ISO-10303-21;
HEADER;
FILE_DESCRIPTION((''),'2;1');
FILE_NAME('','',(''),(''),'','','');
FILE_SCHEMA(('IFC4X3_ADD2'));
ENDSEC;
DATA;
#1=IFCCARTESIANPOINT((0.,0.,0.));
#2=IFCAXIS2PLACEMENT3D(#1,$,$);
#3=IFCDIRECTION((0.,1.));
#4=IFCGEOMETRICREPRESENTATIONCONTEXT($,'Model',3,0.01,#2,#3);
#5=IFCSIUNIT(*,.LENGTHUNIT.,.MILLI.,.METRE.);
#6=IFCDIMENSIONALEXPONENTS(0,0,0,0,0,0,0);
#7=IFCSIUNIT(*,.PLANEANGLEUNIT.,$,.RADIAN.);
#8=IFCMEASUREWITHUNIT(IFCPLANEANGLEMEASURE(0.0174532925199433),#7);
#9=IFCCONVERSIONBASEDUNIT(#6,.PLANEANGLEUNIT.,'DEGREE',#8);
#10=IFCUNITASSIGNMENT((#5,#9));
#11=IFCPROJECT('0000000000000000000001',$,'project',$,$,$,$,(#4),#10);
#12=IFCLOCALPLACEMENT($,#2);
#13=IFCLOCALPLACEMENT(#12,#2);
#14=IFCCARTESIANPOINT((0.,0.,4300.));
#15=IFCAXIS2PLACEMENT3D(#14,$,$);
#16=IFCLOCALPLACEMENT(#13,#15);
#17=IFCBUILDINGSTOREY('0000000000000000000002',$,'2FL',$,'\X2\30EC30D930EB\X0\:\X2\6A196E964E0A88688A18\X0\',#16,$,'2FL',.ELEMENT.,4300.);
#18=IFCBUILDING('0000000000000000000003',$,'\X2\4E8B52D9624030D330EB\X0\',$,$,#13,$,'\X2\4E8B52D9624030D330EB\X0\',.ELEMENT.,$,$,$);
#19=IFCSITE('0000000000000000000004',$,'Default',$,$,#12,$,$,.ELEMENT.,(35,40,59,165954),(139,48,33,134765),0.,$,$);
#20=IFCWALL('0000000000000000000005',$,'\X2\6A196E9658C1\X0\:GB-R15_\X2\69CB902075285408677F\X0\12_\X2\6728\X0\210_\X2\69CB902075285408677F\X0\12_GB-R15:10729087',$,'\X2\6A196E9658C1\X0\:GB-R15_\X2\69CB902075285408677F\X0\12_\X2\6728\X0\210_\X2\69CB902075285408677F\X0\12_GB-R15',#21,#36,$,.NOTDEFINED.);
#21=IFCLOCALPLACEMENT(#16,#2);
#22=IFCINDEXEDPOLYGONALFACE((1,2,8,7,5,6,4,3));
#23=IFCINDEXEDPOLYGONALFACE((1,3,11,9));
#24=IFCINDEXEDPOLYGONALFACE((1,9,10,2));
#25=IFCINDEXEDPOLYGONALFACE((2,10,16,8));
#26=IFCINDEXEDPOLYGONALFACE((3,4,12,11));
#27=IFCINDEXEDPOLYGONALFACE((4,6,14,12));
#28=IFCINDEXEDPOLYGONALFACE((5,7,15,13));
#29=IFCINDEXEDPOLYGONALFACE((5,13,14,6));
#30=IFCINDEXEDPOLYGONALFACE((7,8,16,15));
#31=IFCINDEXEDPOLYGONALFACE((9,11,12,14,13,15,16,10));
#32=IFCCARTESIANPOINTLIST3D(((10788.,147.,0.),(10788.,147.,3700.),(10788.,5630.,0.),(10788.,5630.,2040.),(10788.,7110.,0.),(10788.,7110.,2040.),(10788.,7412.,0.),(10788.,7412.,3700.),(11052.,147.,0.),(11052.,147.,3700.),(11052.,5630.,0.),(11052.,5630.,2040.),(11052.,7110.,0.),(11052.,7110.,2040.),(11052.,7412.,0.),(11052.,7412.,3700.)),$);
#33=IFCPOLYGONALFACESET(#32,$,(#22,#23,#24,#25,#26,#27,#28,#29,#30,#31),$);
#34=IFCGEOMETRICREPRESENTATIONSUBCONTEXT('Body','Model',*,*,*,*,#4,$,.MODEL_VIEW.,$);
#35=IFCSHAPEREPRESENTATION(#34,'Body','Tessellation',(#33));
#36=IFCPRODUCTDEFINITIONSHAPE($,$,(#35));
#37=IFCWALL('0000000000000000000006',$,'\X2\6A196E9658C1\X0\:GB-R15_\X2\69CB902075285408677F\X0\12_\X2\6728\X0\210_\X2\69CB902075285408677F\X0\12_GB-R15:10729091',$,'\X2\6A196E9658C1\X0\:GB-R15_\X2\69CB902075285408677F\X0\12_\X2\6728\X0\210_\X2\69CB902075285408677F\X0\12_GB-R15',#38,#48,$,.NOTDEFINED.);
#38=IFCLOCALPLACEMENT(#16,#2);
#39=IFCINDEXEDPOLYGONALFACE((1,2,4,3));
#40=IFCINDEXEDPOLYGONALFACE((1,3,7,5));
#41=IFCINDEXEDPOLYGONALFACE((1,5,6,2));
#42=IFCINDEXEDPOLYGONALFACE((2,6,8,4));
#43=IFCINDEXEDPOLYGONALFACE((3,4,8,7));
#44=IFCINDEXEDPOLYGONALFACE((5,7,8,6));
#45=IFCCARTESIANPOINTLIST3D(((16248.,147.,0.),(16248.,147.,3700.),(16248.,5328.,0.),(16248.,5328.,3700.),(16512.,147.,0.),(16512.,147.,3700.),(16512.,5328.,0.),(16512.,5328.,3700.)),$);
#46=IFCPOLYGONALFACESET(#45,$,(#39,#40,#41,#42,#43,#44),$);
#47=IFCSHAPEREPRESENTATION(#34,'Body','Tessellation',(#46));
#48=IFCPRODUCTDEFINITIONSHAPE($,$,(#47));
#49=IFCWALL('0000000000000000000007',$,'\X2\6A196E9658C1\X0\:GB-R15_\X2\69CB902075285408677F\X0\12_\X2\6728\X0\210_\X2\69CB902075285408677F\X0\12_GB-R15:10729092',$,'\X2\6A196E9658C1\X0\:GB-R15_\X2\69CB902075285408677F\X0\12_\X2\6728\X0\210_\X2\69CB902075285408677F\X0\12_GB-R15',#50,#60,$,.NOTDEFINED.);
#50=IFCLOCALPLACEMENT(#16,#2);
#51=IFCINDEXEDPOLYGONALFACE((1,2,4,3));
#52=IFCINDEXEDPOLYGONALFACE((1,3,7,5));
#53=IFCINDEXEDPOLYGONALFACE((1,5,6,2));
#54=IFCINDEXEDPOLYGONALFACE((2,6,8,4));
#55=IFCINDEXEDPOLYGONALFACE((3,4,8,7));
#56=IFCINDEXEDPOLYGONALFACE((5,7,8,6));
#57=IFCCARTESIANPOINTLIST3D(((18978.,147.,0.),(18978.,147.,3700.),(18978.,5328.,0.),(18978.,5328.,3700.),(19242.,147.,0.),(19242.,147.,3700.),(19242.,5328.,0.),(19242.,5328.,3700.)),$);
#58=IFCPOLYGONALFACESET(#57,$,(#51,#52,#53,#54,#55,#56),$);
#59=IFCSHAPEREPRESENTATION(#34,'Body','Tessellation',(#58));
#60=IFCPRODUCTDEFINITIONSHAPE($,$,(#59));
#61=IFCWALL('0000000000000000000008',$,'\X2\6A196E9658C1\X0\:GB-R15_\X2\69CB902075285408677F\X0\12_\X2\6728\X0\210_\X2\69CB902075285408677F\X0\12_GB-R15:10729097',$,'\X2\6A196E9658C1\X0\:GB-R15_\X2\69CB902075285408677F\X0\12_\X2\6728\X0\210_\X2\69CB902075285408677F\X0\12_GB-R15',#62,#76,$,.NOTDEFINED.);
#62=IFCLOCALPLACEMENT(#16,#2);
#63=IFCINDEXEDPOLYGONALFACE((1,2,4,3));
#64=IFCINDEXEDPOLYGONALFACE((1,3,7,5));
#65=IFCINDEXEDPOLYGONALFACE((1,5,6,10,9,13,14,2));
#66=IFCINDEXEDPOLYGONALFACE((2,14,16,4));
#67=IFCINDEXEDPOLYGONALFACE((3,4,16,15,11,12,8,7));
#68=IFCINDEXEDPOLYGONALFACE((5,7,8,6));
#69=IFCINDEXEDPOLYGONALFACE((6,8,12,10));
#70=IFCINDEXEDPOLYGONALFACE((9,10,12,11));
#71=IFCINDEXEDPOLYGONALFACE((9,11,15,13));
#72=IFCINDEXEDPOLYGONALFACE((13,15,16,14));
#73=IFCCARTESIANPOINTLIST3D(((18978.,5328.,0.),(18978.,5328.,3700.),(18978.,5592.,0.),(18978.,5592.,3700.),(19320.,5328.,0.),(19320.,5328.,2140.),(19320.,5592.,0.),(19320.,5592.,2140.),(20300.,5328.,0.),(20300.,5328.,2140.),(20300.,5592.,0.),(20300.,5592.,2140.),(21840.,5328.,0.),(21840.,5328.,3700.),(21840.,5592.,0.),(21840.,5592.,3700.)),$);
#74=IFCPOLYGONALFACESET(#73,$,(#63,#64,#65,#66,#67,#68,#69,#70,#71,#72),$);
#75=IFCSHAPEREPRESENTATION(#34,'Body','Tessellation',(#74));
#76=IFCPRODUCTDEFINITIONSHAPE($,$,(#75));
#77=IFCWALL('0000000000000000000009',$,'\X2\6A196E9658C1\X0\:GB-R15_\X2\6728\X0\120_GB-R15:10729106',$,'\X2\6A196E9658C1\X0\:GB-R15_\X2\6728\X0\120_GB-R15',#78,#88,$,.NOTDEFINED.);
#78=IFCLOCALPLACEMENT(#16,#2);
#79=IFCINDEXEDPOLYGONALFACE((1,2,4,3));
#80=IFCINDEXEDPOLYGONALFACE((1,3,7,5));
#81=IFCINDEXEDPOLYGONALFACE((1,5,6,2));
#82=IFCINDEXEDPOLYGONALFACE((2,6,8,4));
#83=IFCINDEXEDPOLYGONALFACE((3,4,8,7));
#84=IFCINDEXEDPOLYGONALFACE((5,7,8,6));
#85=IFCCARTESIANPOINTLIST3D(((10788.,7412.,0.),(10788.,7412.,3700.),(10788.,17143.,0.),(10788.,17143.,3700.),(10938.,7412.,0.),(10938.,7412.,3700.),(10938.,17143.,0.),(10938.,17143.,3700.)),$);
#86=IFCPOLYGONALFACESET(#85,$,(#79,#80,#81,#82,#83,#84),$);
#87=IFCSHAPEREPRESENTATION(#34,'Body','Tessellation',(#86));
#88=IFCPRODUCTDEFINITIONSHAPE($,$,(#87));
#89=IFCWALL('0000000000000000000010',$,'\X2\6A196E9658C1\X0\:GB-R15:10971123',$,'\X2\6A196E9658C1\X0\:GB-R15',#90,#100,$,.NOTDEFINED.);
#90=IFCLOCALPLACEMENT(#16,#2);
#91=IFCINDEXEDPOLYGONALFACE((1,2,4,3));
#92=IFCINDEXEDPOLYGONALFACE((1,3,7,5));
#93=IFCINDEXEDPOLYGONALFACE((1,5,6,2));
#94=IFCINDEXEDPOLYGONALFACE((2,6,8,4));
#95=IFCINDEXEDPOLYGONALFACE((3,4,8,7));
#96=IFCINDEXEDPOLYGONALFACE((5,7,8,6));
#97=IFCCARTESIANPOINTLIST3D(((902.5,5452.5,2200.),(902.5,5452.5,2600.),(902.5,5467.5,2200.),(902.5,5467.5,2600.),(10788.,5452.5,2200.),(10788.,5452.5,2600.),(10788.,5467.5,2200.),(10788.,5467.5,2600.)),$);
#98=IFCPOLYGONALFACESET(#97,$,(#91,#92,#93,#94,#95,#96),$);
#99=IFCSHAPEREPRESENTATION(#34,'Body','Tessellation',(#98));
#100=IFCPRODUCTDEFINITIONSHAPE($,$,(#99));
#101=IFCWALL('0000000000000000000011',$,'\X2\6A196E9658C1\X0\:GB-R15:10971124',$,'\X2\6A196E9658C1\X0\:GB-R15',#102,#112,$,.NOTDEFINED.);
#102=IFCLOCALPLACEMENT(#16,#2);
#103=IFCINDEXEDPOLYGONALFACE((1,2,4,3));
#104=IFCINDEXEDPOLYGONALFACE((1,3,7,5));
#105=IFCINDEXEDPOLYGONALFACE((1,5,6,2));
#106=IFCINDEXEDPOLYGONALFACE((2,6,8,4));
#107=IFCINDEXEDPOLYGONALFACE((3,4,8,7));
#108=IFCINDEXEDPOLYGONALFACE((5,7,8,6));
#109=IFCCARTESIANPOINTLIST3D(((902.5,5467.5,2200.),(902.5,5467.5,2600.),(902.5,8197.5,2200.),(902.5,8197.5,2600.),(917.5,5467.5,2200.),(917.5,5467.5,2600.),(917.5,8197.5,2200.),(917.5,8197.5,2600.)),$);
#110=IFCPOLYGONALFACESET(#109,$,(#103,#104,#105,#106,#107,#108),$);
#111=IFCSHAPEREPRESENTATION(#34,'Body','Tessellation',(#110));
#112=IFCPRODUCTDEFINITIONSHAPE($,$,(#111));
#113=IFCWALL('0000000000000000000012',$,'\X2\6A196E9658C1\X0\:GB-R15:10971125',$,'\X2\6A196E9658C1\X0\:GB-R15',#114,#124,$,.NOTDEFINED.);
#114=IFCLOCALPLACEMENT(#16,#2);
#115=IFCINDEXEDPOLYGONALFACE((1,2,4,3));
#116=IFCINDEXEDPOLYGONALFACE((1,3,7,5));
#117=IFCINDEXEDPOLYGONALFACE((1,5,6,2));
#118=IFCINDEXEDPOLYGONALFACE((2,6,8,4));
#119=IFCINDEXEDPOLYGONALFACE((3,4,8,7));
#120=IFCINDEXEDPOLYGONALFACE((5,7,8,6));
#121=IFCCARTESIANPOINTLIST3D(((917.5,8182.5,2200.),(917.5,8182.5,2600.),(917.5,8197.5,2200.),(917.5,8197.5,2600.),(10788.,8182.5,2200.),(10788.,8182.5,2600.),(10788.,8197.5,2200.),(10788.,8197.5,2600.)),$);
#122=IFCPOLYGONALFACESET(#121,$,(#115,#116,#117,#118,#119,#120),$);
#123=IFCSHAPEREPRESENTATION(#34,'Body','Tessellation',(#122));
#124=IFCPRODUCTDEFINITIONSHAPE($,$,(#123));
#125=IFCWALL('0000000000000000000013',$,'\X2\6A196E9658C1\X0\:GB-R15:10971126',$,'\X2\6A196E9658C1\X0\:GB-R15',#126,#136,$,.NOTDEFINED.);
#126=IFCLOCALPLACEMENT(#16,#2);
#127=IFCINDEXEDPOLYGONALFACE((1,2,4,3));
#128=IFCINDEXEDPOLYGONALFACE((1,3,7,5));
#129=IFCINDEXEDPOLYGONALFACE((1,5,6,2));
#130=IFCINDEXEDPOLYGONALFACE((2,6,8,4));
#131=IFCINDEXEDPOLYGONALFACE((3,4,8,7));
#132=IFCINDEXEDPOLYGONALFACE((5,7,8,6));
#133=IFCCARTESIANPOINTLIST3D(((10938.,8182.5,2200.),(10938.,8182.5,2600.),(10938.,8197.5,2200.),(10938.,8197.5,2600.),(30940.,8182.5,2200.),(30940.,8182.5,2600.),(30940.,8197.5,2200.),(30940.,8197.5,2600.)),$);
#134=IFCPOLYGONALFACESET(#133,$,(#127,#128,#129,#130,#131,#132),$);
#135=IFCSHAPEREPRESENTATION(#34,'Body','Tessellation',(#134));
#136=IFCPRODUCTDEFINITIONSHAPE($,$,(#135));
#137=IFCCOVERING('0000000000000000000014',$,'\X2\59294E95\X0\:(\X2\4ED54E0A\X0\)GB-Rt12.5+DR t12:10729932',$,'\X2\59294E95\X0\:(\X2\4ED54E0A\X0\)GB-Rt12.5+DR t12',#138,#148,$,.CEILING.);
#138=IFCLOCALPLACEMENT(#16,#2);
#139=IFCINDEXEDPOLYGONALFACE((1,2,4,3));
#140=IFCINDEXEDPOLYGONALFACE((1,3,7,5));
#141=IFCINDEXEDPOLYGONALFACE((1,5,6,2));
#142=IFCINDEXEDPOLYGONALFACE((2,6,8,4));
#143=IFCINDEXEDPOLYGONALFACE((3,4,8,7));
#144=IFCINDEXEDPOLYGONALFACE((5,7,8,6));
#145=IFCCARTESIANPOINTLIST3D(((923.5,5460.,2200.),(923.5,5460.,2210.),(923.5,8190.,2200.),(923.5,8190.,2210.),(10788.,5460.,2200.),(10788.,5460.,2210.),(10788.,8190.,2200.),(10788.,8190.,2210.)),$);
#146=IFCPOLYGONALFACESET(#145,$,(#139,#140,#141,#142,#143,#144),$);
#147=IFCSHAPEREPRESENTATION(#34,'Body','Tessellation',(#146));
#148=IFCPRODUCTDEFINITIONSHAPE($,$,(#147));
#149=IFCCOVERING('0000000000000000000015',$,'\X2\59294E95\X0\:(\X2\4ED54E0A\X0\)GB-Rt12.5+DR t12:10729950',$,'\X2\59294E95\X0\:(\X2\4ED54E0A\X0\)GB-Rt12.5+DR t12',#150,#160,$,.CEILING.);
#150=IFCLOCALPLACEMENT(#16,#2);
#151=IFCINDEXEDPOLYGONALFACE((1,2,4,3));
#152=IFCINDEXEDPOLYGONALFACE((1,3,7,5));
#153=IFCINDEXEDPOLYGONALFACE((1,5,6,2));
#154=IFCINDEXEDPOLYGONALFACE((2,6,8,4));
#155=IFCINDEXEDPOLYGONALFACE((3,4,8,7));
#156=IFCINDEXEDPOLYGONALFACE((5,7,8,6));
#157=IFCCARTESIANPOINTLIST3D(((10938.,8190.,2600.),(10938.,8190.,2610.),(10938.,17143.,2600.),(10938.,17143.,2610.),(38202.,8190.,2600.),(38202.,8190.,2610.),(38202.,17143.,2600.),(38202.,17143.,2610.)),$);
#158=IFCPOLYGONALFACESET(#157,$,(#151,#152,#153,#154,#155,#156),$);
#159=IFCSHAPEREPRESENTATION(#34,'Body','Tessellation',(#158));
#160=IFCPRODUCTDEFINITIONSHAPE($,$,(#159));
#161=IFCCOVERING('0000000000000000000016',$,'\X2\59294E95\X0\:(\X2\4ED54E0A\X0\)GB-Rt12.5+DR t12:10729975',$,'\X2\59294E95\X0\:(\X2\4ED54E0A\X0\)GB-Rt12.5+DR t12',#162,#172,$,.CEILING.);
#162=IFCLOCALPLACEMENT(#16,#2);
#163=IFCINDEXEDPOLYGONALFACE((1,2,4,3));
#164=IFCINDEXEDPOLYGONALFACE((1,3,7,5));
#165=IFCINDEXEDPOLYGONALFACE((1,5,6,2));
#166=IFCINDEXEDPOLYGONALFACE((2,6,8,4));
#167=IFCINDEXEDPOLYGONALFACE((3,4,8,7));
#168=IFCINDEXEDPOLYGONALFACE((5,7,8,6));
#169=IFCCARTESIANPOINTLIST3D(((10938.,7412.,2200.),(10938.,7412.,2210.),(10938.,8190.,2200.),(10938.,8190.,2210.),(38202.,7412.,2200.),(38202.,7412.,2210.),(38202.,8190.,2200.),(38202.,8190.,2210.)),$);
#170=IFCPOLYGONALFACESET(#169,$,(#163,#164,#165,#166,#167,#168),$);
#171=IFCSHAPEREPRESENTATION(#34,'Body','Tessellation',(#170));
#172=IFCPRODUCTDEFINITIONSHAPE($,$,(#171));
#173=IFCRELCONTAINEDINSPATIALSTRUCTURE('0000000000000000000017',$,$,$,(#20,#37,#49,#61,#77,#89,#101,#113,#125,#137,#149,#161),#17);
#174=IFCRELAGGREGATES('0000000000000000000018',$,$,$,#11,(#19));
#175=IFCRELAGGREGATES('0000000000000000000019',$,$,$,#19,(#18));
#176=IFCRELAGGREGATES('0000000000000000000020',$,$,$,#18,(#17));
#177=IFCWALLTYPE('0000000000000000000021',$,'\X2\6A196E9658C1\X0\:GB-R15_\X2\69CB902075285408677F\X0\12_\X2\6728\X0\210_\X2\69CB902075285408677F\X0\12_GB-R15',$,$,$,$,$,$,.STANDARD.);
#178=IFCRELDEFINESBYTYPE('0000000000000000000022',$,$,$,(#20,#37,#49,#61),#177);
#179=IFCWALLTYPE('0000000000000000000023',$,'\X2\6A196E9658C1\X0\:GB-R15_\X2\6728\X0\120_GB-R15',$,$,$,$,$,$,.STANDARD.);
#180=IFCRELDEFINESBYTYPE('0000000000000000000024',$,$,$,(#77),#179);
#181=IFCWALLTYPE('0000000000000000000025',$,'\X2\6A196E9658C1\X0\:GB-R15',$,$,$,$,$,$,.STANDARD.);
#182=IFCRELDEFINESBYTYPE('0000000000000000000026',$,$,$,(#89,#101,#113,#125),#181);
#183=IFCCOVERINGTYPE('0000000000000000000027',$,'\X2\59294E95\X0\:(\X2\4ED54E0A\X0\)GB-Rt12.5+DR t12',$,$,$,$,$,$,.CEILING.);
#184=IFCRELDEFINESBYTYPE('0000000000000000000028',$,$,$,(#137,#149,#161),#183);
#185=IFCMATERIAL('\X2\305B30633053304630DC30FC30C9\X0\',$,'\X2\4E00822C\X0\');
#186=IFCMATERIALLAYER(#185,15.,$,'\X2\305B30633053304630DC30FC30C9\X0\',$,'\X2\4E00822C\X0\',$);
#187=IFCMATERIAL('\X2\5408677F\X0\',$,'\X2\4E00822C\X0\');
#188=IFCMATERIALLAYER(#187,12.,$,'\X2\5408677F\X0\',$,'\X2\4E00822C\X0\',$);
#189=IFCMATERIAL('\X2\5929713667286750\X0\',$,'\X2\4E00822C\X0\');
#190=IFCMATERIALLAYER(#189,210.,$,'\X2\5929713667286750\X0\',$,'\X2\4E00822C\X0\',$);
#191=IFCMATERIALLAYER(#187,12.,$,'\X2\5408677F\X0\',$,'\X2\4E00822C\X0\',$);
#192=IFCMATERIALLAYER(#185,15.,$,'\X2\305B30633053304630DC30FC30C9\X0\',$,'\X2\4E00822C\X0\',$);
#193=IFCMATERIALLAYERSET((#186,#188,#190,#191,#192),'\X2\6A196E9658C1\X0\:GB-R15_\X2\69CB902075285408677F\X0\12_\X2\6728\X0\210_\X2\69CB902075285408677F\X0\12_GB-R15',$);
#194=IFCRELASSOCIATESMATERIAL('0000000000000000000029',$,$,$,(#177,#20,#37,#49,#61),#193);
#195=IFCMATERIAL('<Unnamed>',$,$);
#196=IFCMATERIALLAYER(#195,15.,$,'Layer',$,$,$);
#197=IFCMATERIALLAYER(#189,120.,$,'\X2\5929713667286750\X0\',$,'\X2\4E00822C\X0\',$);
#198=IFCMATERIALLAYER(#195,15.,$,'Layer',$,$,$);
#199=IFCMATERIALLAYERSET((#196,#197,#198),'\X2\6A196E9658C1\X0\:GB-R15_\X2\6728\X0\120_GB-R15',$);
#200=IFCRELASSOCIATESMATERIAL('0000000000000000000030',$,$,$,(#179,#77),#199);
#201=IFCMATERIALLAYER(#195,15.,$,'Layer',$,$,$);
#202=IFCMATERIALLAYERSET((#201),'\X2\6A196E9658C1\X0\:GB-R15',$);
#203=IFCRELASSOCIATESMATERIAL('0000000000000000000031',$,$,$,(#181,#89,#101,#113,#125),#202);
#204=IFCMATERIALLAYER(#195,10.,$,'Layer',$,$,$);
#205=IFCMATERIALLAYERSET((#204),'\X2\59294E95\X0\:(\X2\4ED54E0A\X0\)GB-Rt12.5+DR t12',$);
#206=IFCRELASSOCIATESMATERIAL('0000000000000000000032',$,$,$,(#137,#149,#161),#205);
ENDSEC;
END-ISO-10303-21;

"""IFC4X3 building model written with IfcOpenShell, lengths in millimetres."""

from ifc_helpers import new_model, entity, si_unit, converted_unit, direction, frame, frame_2d, origin, place, context, subcontext, project, spatial, rectangle, extrude, material, layer, layer_set, layer_usage, type_object, element, save


model = new_model("IFC4X3")

# Units and contexts
model_context = context("Model", 3, precision=0.01, world=origin(), true_north=direction((0.0, 1.0)))
body_context = subcontext(model_context, "Body", "Model", "MODEL_VIEW")
ifc_project = project(units=[si_unit("LENGTHUNIT", "METRE", prefix="MILLI"), converted_unit("PLANEANGLEUNIT", "DEGREE", entity("IfcPlaneAngleMeasure", 0.0174532925199433), si_unit("PLANEANGLEUNIT", "RADIAN"), dimensions=[0, 0, 0, 0, 0, 0, 0])], contexts=[model_context])

# Site, building, storey
site_placement = place(None, origin())
site = spatial("IfcSite", under=ifc_project, at=site_placement, Name="Default", CompositionType="ELEMENT", RefLatitude=(35, 40, 59, 165954), RefLongitude=(139, 48, 33, 134765), RefElevation=0.0)
building_placement = place(site_placement, origin())
building = spatial("IfcBuilding", under=site, at=building_placement, Name="事務所ビル", LongName="事務所ビル", CompositionType="ELEMENT")
storey_placement = place(building_placement, frame((0.0, 0.0, 4300.0)))
storey = spatial("IfcBuildingStorey", under=building, at=storey_placement, Name="2FL", ObjectType="レベル:標準上表記", LongName="2FL", CompositionType="ELEMENT", Elevation=4300.0)

# Shared definitions
ifc_material_1 = material(Name="<Unnamed>")
ifc_material_2 = material(Name="合板", Category="一般")

# Wall, opening
ifc_material_3 = material(Name="せっこうボード", Category="一般")
ifc_layer_1 = layer(ifc_material_3, 15.0, Name="せっこうボード", Category="一般")
ifc_layer_2 = layer(ifc_material_2, 12.0, Name="合板", Category="一般")
ifc_material_4 = material(Name="天然木材", Category="一般")
ifc_layer_3 = layer(ifc_material_4, 210.0, Name="天然木材", Category="一般")
ifc_layer_4 = layer(ifc_material_2, 12.0, Name="合板", Category="一般")
ifc_layer_5 = layer(ifc_material_3, 15.0, Name="せっこうボード", Category="一般")
ifc_layer_set_1 = layer_set([ifc_layer_1, ifc_layer_2, ifc_layer_3, ifc_layer_4, ifc_layer_5], Name="標準壁:GB-R15_構造用合板12_木210_構造用合板12_GB-R15")
wall_type_1 = type_object("IfcWallType", Name="標準壁:GB-R15_構造用合板12_木210_構造用合板12_GB-R15", PredefinedType="STANDARD", material=ifc_layer_set_1)
wall_1_placement = place(storey_placement, frame((10920.0, 147.0, 0.0), z_axis=(0.0, 0.0, 1.0), x_axis=(0.0, 1.0, 0.0)))
wall_1 = element("IfcWall", 1, at=wall_1_placement, inside=storey, type_object=wall_type_1, material=ifc_layer_set_1, Name="標準壁:GB-R15_構造用合板12_木210_構造用合板12_GB-R15:10729087", ObjectType="標準壁:GB-R15_構造用合板12_木210_構造用合板12_GB-R15", PredefinedType="NOTDEFINED", context=body_context, shape_type="SweptSolid", body=[
    extrude(rectangle(XDim=7265.0, YDim=264.0, at=frame_2d((3632.5, 0.0), x_axis=(1.0, 0.0))), origin(), (0.0, 0.0, 1.0), 3700.0),
])
opening_1_placement = place(wall_1_placement, frame((5483.0, -132.0, -15.0)))
element("IfcOpeningElement", 2, at=opening_1_placement, cuts=wall_1, PredefinedType="OPENING", context=body_context, shape_type="SweptSolid", body=[
    extrude(rectangle(XDim=2055.0, YDim=1480.0, at=frame_2d((1027.5, 740.0), x_axis=(-1.0, 0.0))), frame((0.0, 0.0, 0.0), z_axis=(0.0, 1.0, 0.0), x_axis=(0.0, 0.0, 1.0)), (0.0, 0.0, 1.0), 264.0),
])

# Walls
wall_2_placement = place(storey_placement, frame((16380.0, 147.0, 0.0), z_axis=(0.0, 0.0, 1.0), x_axis=(0.0, 1.0, 0.0)))
element("IfcWall", 3, at=wall_2_placement, inside=storey, type_object=wall_type_1, material=ifc_layer_set_1, Name="標準壁:GB-R15_構造用合板12_木210_構造用合板12_GB-R15:10729091", ObjectType="標準壁:GB-R15_構造用合板12_木210_構造用合板12_GB-R15", PredefinedType="NOTDEFINED", context=body_context, shape_type="SweptSolid", body=[
    extrude(rectangle(XDim=5181.0, YDim=264.0, at=frame_2d((2590.5, 0.0), x_axis=(-1.0, 0.0))), origin(), (0.0, 0.0, 1.0), 3700.0),
])
wall_3_placement = place(storey_placement, frame((19110.0, 147.0, 0.0), z_axis=(0.0, 0.0, 1.0), x_axis=(0.0, 1.0, 0.0)))
element("IfcWall", 4, at=wall_3_placement, inside=storey, type_object=wall_type_1, material=ifc_layer_set_1, Name="標準壁:GB-R15_構造用合板12_木210_構造用合板12_GB-R15:10729092", ObjectType="標準壁:GB-R15_構造用合板12_木210_構造用合板12_GB-R15", PredefinedType="NOTDEFINED", context=body_context, shape_type="SweptSolid", body=[
    extrude(rectangle(XDim=5181.0, YDim=264.0, at=frame_2d((2590.5, 0.0), x_axis=(-1.0, 0.0))), origin(), (0.0, 0.0, 1.0), 3700.0),
])

# Wall, openings
wall_4_placement = place(storey_placement, frame((18978.0, 5460.0, 0.0)))
wall_4 = element("IfcWall", 5, at=wall_4_placement, inside=storey, type_object=wall_type_1, material=ifc_layer_set_1, Name="標準壁:GB-R15_構造用合板12_木210_構造用合板12_GB-R15:10729097", ObjectType="標準壁:GB-R15_構造用合板12_木210_構造用合板12_GB-R15", PredefinedType="NOTDEFINED", context=body_context, shape_type="SweptSolid", body=[
    extrude(rectangle(XDim=2862.0, YDim=264.0, at=frame_2d((1431.0, 0.0), x_axis=(-1.0, 0.0))), origin(), (0.0, 0.0, 1.0), 3700.0),
])
opening_2_placement = place(wall_4_placement, frame((-18978.0, -5460.0, 3700.0)))
element("IfcOpeningElement", 6, at=opening_2_placement, cuts=wall_4, PredefinedType="OPENING", context=body_context, shape_type="SweptSolid", body=[
    extrude(rectangle(XDim=2140.0, YDim=980.0, at=frame_2d((0.0, 0.0), x_axis=(0.0, 1.0))), frame((19810.0, 3804.0, 1070.0), z_axis=(0.0, 1.0, 0.0), x_axis=(1.0, 0.0, 0.0)), (0.0, 0.0, 1.0), 3048.0),
])
opening_3_placement = place(wall_4_placement, frame((342.0, -132.0, 0.0)))
element("IfcOpeningElement", 7, at=opening_3_placement, cuts=wall_4, PredefinedType="OPENING", context=body_context, shape_type="SweptSolid", body=[
    extrude(rectangle(XDim=2140.0, YDim=980.0, at=frame_2d((1070.0, 490.0), x_axis=(-1.0, 0.0))), frame((0.0, 0.0, 0.0), z_axis=(0.0, 1.0, 0.0), x_axis=(0.0, 0.0, 1.0)), (0.0, 0.0, 1.0), 264.0),
])

# Walls
ifc_layer_6 = layer(ifc_material_1, 15.0, Name="Layer")
ifc_layer_7 = layer(ifc_material_4, 120.0, Name="天然木材", Category="一般")
ifc_layer_8 = layer(ifc_material_1, 15.0, Name="Layer")
ifc_layer_set_2 = layer_set([ifc_layer_6, ifc_layer_7, ifc_layer_8], Name="標準壁:GB-R15_木120_GB-R15")
wall_type_2 = type_object("IfcWallType", Name="標準壁:GB-R15_木120_GB-R15", PredefinedType="STANDARD", material=ifc_layer_set_2)
wall_5_placement = place(storey_placement, frame((10863.0, 7412.0, 0.0), z_axis=(0.0, 0.0, 1.0), x_axis=(0.0, 1.0, 0.0)))
element("IfcWall", 8, at=wall_5_placement, inside=storey, type_object=wall_type_2, material=ifc_layer_set_2, Name="標準壁:GB-R15_木120_GB-R15:10729106", ObjectType="標準壁:GB-R15_木120_GB-R15", PredefinedType="NOTDEFINED", context=body_context, shape_type="SweptSolid", body=[
    extrude(rectangle(XDim=9731.0, YDim=150.0, at=frame_2d((4865.5, 0.0), x_axis=(-1.0, 0.0))), origin(), (0.0, 0.0, 1.0), 3700.0),
])
ifc_layer_9 = layer(ifc_material_1, 15.0, Name="Layer")
ifc_layer_set_3 = layer_set([ifc_layer_9], Name="標準壁:GB-R15")
wall_type_3 = type_object("IfcWallType", Name="標準壁:GB-R15", PredefinedType="STANDARD", material=ifc_layer_set_3)
wall_6_placement = place(storey_placement, frame((10788.0, 5460.0, 2200.0), z_axis=(0.0, 0.0, 1.0), x_axis=(-1.0, 0.0, 0.0)))
element("IfcWall", 9, at=wall_6_placement, inside=storey, type_object=wall_type_3, material=ifc_layer_set_3, Name="標準壁:GB-R15:10971123", ObjectType="標準壁:GB-R15", PredefinedType="NOTDEFINED", context=body_context, shape_type="SweptSolid", body=[
    extrude(rectangle(XDim=9885.5, YDim=15.0, at=frame_2d((4942.8, 0.0), x_axis=(-1.0, 0.0))), origin(), (0.0, 0.0, 1.0), 400.0),
])
wall_7_placement = place(storey_placement, frame((910.0, 5467.5, 2200.0), z_axis=(0.0, 0.0, 1.0), x_axis=(0.0, 1.0, 0.0)))
element("IfcWall", 10, at=wall_7_placement, inside=storey, type_object=wall_type_3, material=ifc_layer_set_3, Name="標準壁:GB-R15:10971124", ObjectType="標準壁:GB-R15", PredefinedType="NOTDEFINED", context=body_context, shape_type="SweptSolid", body=[
    extrude(rectangle(XDim=2730.0, YDim=15.0, at=frame_2d((1365.0, 0.0), x_axis=(-1.0, 0.0))), origin(), (0.0, 0.0, 1.0), 400.0),
])
wall_8_placement = place(storey_placement, frame((917.5, 8190.0, 2200.0)))
element("IfcWall", 11, at=wall_8_placement, inside=storey, type_object=wall_type_3, material=ifc_layer_set_3, Name="標準壁:GB-R15:10971125", ObjectType="標準壁:GB-R15", PredefinedType="NOTDEFINED", context=body_context, shape_type="SweptSolid", body=[
    extrude(rectangle(XDim=9870.5, YDim=15.0, at=frame_2d((4935.2, 0.0), x_axis=(-1.0, 0.0))), origin(), (0.0, 0.0, 1.0), 400.0),
])
wall_9_placement = place(storey_placement, frame((10938.0, 8190.0, 2200.0)))
element("IfcWall", 12, at=wall_9_placement, inside=storey, type_object=wall_type_3, material=ifc_layer_set_3, Name="標準壁:GB-R15:10971126", ObjectType="標準壁:GB-R15", PredefinedType="NOTDEFINED", context=body_context, shape_type="SweptSolid", body=[
    extrude(rectangle(XDim=20002.0, YDim=15.0, at=frame_2d((10001.0, 0.0), x_axis=(-1.0, 0.0))), origin(), (0.0, 0.0, 1.0), 400.0),
])

# Covering
ifc_layer_10 = layer(ifc_material_1, 10.0, Name="Layer")
ifc_layer_set_4 = layer_set([ifc_layer_10], Name="天井:(仕上)GB-Rt12.5+DR t12")
ifc_layer_usage_1 = layer_usage(ifc_layer_set_4, "AXIS3", "NEGATIVE", 0.0)
covering_type = type_object("IfcCoveringType", Name="天井:(仕上)GB-Rt12.5+DR t12", PredefinedType="CEILING")
covering_1_placement = place(storey_placement, frame((923.5, 5460.0, 2200.0)))
element("IfcCovering", 13, at=covering_1_placement, inside=storey, type_object=covering_type, material=ifc_layer_usage_1, Name="天井:(仕上)GB-Rt12.5+DR t12:10729932", ObjectType="天井:(仕上)GB-Rt12.5+DR t12", PredefinedType="CEILING", context=body_context, shape_type="SweptSolid", body=[
    extrude(rectangle(XDim=9864.5, YDim=2730.0, at=frame_2d((0.0, 0.0), x_axis=(1.0, 0.0))), frame((4932.2, 1365.0, 0.0)), (0.0, 0.0, 1.0), 10.0),
])

# Coverings
ifc_layer_usage_2 = layer_usage(ifc_layer_set_4, "AXIS3", "NEGATIVE", 0.0)
covering_2_placement = place(storey_placement, frame((10938.0, 8190.0, 2600.0)))
element("IfcCovering", 14, at=covering_2_placement, inside=storey, type_object=covering_type, material=ifc_layer_usage_2, Name="天井:(仕上)GB-Rt12.5+DR t12:10729950", ObjectType="天井:(仕上)GB-Rt12.5+DR t12", PredefinedType="CEILING", context=body_context, shape_type="SweptSolid", body=[
    extrude(rectangle(XDim=8953.0, YDim=27264.0, at=frame_2d((0.0, 0.0), x_axis=(1.0, 0.0))), frame((13632.0, 4476.5, 0.0), z_axis=(0.0, 0.0, 1.0), x_axis=(0.0, 1.0, 0.0)), (0.0, 0.0, 1.0), 10.0),
])
ifc_layer_usage_3 = layer_usage(ifc_layer_set_4, "AXIS3", "NEGATIVE", 0.0)
covering_3_placement = place(storey_placement, frame((10938.0, 7412.0, 2200.0)))
element("IfcCovering", 15, at=covering_3_placement, inside=storey, type_object=covering_type, material=ifc_layer_usage_3, Name="天井:(仕上)GB-Rt12.5+DR t12:10729975", ObjectType="天井:(仕上)GB-Rt12.5+DR t12", PredefinedType="CEILING", context=body_context, shape_type="SweptSolid", body=[
    extrude(rectangle(XDim=27264.0, YDim=778.0, at=frame_2d((0.0, 0.0), x_axis=(1.0, 0.0))), frame((13632.0, 389.0, 0.0), z_axis=(0.0, 0.0, 1.0), x_axis=(-1.0, 0.0, 0.0)), (0.0, 0.0, 1.0), 10.0),
])

save(model, "model.ifc")
